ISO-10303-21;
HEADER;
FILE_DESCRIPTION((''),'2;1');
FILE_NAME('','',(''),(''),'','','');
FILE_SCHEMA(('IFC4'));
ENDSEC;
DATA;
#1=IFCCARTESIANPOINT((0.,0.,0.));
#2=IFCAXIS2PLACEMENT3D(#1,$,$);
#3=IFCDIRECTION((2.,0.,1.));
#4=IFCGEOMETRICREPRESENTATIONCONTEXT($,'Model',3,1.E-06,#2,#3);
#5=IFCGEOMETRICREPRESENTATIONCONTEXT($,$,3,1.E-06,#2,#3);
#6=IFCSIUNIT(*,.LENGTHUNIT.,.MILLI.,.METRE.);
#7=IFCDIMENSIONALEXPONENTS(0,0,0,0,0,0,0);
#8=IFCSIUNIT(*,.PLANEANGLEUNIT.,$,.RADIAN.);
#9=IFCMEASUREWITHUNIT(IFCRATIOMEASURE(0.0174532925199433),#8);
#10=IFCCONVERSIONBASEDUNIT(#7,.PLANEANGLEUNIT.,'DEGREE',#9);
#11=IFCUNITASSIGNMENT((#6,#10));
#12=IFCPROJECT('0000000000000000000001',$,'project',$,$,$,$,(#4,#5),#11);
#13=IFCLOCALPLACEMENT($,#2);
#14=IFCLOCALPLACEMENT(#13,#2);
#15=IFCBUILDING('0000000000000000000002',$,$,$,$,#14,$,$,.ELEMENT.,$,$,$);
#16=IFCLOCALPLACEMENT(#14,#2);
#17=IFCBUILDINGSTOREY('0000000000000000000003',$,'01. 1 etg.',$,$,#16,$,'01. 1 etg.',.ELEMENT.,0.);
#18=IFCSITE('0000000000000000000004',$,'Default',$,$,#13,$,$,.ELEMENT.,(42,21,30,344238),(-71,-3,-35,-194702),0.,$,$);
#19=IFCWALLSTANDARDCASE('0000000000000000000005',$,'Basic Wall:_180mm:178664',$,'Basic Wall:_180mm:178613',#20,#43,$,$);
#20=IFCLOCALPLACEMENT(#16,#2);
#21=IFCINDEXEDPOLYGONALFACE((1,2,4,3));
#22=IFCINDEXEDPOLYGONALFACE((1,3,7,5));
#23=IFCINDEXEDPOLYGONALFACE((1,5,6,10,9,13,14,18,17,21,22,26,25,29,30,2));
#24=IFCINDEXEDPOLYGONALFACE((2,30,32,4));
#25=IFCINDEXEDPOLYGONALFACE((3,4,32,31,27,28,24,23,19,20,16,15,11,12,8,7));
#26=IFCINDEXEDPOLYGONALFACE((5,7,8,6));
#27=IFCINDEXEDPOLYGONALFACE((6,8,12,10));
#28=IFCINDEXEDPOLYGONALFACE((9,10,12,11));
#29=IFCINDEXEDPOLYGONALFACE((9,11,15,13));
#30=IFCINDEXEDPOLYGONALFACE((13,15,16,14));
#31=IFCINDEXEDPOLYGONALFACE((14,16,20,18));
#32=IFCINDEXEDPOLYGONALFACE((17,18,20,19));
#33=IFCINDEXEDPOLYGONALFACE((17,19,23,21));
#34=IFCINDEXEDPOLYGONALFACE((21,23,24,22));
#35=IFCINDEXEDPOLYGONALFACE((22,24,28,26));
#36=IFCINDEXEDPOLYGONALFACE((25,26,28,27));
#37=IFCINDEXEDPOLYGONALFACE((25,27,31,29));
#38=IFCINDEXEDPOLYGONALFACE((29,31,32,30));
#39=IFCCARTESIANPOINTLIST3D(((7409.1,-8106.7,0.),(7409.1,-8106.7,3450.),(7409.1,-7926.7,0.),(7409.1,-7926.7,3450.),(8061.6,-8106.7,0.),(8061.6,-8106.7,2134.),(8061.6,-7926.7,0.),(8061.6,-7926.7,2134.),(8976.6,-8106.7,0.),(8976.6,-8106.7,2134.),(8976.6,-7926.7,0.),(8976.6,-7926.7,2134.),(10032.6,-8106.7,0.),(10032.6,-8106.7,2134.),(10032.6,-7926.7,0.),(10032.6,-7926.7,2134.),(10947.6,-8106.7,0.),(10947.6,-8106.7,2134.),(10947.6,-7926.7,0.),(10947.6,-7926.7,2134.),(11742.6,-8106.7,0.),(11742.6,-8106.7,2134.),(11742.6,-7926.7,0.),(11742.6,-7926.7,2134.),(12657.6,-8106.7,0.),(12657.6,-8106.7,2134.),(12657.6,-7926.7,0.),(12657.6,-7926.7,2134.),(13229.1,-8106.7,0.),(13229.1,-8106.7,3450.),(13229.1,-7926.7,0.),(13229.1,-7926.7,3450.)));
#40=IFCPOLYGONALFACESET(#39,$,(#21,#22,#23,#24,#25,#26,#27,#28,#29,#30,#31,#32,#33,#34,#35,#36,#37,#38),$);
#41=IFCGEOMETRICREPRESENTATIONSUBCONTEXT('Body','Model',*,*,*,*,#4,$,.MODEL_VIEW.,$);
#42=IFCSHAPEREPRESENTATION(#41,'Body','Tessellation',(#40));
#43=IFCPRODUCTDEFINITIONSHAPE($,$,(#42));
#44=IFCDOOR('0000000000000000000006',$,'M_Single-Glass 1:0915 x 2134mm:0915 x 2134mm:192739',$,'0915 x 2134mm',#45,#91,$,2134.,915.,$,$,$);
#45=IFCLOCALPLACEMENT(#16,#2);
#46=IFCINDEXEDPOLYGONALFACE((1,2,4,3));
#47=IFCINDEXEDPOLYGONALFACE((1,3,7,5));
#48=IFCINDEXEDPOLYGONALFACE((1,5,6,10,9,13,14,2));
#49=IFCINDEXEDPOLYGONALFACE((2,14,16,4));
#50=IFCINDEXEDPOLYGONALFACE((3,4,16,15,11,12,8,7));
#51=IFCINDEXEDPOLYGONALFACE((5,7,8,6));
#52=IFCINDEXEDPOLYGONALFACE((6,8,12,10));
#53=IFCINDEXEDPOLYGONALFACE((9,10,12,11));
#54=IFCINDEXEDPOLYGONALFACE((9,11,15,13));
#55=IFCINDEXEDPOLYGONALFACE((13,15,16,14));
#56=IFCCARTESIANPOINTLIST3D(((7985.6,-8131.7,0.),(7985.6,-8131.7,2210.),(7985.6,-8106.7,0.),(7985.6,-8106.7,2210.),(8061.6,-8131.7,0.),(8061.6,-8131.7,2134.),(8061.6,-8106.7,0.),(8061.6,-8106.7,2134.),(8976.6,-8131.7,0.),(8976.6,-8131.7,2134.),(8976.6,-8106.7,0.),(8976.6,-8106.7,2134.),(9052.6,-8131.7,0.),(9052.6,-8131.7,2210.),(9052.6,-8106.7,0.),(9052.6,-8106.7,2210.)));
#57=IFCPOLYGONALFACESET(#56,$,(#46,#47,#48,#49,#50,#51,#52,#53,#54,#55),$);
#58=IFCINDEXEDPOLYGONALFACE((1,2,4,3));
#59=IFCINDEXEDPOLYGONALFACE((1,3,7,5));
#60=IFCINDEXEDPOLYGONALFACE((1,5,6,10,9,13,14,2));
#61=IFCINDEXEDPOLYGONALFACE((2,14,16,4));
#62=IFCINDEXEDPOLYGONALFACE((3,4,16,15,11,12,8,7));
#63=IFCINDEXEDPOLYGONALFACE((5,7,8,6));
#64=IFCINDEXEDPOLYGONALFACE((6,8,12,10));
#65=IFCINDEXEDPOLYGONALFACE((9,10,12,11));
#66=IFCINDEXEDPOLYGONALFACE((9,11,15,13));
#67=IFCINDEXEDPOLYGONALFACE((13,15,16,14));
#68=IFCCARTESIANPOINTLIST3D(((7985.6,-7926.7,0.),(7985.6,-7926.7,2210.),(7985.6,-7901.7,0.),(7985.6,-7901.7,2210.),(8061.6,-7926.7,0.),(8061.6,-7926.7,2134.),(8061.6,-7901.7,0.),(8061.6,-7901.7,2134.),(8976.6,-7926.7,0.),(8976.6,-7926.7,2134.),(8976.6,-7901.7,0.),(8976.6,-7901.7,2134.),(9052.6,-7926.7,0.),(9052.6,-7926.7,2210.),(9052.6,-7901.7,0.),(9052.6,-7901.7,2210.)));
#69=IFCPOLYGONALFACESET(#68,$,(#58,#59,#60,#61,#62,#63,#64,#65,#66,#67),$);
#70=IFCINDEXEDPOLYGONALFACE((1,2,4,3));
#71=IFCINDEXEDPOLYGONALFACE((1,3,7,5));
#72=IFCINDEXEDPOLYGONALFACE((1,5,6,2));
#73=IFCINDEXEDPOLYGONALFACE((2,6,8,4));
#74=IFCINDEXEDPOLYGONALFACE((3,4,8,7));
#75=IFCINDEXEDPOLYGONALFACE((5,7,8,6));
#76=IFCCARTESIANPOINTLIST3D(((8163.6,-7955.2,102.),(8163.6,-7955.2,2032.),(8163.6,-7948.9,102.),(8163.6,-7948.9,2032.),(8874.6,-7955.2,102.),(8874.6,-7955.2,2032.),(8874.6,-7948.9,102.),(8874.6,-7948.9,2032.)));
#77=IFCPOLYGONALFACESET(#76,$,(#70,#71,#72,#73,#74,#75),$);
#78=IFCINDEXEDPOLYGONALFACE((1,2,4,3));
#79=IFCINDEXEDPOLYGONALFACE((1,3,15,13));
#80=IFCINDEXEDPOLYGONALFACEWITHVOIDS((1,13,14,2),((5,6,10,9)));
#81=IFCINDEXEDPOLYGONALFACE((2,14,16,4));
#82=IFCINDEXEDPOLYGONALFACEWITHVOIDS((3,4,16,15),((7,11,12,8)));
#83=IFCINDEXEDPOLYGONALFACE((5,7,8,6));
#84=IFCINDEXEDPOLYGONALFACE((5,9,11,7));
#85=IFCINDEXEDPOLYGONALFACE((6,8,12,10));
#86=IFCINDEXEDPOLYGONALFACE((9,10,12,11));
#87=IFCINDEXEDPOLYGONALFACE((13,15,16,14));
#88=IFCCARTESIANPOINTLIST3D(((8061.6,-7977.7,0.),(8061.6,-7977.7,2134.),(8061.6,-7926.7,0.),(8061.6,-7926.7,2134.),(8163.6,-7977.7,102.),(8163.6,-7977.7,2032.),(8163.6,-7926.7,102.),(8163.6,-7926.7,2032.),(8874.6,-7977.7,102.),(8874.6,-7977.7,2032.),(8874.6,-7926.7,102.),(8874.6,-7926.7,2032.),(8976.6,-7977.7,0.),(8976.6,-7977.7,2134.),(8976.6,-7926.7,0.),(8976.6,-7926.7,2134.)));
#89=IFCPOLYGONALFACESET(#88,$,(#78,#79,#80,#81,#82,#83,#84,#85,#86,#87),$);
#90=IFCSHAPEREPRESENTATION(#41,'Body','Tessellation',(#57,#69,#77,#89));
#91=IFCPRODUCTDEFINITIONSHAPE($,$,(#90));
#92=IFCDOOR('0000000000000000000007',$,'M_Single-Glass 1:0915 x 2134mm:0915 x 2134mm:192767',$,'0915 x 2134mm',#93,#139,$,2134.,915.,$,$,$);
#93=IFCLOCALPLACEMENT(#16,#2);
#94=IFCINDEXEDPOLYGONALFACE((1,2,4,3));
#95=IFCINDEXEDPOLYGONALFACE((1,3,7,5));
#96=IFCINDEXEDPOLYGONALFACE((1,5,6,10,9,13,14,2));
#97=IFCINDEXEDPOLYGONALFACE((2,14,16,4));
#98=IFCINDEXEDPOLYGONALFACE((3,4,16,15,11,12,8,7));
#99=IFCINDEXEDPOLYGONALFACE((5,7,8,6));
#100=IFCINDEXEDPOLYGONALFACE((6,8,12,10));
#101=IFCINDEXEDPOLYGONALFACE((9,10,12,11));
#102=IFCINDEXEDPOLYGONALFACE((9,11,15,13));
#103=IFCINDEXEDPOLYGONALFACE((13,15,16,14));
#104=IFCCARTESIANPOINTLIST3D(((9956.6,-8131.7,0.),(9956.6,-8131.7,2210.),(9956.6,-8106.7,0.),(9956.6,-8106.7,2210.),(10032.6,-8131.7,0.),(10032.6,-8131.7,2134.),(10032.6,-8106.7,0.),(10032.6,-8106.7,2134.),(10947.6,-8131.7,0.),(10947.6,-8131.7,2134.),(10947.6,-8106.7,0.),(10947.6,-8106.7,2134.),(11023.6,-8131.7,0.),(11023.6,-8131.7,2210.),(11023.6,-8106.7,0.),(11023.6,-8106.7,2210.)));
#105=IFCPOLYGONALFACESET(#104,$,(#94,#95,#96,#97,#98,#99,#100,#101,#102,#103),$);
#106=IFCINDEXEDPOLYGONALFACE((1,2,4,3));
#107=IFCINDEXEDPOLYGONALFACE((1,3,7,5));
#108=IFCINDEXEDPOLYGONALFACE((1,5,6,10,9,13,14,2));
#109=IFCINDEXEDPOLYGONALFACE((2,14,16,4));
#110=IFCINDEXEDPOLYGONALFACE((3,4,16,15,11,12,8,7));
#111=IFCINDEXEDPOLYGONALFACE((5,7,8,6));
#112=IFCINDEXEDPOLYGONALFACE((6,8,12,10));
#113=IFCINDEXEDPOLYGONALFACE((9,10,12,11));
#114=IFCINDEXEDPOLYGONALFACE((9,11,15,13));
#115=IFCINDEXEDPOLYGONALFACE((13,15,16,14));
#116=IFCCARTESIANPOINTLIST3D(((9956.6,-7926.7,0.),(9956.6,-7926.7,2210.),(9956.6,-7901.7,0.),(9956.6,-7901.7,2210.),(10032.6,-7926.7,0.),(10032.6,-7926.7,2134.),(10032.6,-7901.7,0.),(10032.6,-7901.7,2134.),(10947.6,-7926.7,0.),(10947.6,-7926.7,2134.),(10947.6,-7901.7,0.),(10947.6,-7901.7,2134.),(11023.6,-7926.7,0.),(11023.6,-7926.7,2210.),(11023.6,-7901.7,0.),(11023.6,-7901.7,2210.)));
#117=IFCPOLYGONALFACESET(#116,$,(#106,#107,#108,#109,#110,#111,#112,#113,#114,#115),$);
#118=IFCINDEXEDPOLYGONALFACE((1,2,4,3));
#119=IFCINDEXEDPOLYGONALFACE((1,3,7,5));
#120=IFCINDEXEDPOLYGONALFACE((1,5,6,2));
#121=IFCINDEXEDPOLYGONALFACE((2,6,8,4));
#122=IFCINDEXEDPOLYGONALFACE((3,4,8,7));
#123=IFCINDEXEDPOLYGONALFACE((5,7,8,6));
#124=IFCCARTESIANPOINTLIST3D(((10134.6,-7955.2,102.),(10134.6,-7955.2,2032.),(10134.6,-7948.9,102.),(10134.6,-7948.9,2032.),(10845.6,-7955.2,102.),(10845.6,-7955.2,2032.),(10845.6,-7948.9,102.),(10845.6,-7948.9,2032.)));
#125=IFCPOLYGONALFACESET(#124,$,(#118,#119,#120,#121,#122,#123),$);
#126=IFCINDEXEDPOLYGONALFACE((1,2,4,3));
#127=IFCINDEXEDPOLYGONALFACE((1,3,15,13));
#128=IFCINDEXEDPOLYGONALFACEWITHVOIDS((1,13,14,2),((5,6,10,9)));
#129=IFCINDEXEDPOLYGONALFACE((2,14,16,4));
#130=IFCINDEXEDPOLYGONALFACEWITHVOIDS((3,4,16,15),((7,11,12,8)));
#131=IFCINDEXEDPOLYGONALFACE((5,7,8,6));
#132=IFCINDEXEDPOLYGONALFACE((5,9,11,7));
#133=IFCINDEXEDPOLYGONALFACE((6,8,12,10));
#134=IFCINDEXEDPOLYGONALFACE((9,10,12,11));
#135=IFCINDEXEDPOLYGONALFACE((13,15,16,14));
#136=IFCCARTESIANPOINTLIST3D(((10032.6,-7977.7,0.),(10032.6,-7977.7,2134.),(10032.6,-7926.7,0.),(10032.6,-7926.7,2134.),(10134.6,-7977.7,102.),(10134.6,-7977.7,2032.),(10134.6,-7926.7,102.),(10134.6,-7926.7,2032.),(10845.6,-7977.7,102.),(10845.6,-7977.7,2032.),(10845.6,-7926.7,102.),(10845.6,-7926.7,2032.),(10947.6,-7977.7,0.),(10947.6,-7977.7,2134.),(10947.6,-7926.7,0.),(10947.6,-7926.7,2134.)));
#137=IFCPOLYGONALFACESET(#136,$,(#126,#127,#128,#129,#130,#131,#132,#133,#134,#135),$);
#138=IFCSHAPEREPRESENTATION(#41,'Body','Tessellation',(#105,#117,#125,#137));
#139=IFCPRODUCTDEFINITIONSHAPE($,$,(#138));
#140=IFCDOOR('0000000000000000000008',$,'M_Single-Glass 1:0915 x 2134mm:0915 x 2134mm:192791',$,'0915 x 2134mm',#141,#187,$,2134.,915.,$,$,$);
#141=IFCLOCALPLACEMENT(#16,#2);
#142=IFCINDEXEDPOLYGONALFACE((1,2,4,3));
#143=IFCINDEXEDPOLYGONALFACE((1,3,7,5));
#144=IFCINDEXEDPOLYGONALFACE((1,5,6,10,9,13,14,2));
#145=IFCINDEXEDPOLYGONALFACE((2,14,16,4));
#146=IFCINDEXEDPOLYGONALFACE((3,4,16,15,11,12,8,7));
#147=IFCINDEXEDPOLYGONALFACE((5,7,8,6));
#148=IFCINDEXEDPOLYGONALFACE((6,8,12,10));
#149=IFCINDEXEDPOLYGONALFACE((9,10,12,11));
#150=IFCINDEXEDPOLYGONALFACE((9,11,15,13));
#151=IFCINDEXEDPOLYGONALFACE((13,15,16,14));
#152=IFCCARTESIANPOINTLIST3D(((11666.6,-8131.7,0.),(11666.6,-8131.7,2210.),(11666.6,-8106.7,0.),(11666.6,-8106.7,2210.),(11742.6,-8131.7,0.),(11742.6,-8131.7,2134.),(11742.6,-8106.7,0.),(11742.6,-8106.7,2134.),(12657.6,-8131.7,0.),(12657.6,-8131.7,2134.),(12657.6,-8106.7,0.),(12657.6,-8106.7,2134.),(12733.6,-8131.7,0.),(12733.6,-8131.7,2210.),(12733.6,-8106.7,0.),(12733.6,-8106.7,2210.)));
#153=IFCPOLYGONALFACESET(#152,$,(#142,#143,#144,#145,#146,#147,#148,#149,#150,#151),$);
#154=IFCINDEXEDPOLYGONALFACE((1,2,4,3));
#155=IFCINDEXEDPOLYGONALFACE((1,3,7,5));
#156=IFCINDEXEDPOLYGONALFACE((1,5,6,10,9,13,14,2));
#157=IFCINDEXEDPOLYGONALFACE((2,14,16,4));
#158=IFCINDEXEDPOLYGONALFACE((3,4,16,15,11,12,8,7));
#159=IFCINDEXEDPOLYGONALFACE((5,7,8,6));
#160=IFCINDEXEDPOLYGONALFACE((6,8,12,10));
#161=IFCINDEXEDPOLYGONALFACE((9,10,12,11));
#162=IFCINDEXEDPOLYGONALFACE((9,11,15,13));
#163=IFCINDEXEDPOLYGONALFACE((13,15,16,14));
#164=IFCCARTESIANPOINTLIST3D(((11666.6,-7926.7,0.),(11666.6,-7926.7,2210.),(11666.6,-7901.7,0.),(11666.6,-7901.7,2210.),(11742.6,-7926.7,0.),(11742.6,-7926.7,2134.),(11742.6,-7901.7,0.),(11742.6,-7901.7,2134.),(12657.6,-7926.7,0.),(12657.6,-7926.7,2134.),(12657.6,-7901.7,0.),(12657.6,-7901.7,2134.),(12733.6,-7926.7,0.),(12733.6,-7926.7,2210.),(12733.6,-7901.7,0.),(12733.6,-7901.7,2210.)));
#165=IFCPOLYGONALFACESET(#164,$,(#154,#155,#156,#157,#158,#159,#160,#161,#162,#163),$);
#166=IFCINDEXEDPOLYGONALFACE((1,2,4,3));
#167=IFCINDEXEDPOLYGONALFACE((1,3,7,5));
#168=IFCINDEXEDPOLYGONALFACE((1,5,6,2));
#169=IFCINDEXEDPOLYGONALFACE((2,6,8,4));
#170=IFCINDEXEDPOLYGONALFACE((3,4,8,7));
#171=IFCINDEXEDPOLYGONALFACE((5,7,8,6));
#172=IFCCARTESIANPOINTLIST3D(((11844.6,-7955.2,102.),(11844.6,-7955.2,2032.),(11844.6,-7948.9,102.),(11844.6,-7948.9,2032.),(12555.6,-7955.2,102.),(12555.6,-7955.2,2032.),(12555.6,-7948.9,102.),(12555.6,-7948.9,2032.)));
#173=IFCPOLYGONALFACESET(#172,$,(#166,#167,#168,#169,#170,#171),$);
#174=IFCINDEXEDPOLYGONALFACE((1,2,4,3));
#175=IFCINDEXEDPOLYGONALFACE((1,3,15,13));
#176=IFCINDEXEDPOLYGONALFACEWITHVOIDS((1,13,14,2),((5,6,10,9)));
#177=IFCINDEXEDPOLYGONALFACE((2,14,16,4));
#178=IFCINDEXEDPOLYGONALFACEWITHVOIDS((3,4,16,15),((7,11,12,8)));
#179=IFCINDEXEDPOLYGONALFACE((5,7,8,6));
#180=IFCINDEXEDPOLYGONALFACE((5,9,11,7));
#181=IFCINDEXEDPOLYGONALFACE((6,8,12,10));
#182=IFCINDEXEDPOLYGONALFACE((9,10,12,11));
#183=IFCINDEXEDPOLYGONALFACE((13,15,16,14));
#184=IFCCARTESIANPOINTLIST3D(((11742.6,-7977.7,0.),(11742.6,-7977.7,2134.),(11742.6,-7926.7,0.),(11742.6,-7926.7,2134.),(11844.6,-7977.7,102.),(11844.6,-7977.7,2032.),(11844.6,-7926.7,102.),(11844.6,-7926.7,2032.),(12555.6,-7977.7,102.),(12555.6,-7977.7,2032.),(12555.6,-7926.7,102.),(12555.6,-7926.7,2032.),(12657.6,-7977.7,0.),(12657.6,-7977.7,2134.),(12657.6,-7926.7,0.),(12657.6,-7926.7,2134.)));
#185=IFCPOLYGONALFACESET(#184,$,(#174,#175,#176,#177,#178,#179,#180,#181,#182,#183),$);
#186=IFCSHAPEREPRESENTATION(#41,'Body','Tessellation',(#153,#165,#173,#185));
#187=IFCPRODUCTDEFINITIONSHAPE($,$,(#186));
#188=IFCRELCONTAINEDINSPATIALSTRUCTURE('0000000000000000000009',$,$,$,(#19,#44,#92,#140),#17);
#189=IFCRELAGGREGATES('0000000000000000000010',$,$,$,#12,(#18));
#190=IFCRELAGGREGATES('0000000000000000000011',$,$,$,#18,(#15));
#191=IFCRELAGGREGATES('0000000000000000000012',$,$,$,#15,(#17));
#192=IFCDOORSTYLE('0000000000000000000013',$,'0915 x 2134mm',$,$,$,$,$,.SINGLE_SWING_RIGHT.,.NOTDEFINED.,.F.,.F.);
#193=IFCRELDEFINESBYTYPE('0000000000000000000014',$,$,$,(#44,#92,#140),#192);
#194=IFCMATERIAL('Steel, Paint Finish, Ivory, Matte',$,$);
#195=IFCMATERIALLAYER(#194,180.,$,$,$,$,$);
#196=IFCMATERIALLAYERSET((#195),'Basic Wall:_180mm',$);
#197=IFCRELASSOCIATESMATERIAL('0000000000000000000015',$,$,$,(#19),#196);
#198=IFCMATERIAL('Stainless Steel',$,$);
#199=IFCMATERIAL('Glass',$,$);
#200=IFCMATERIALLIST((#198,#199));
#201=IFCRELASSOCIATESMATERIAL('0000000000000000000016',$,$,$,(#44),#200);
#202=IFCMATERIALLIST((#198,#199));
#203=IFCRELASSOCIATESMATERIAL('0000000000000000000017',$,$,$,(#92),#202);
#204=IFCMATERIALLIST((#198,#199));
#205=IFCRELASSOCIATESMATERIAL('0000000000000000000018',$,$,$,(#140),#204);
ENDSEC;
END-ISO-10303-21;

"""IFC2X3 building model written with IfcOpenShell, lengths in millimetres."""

from ifc_helpers import new_model, entity, si_unit, converted_unit, direction, frame, frame_2d, origin, place, context, subcontext, project, spatial, polyline, rectangle, outline, extrude, clip, bounded_halfspace, source, transform, mapped, material, material_list, layer, layer_set, layer_usage, type_object, type_shapes, element, fill, save


model = new_model("IFC2X3")

# Units and contexts
model_context = context("Model", 3, precision=1e-06, world=origin(), true_north=direction((2.0, 0.0, 1.0)))
context_of_model = context(None, 3, precision=1e-06, world=origin(), true_north=direction((2.0, 0.0, 1.0)))
body_context = subcontext(model_context, "Body", "Model", "MODEL_VIEW")
ifc_project = project(units=[si_unit("LENGTHUNIT", "METRE", prefix="MILLI"), converted_unit("PLANEANGLEUNIT", "DEGREE", entity("IfcRatioMeasure", 0.0174532925199433), si_unit("PLANEANGLEUNIT", "RADIAN"), dimensions=[0, 0, 0, 0, 0, 0, 0])], contexts=[model_context, context_of_model])

# Site, building, storey
site_placement = place(None, origin())
site = spatial("IfcSite", under=ifc_project, at=site_placement, Name="Default", CompositionType="ELEMENT", RefLatitude=(42, 21, 30, 344238), RefLongitude=(-71, -3, -35, -194702), RefElevation=0.0)
building_placement = place(site_placement, origin())
building = spatial("IfcBuilding", under=site, at=building_placement, CompositionType="ELEMENT")
storey_placement = place(building_placement, origin())
storey = spatial("IfcBuildingStorey", under=building, at=storey_placement, Name="01. 1 etg.", LongName="01. 1 etg.", CompositionType="ELEMENT", Elevation=0.0)

# Shared definitions
ifc_material_1 = material(Name="Steel, Paint Finish, Ivory, Matte")
ifc_material_2 = material(Name="Stainless Steel")
ifc_material_3 = material(Name="Glass")

# Wall, openings, doors
ifc_layer_1 = layer(ifc_material_1, 180.0)
ifc_layer_set_1 = layer_set([ifc_layer_1], Name="Basic Wall:_180mm")
ifc_layer_usage_1 = layer_usage(ifc_layer_set_1, "AXIS2", "NEGATIVE", 90.0)
wall_1_placement = place(storey_placement, frame((13229.1, -8016.7, 0.0), z_axis=(0.0, 0.0, 1.0), x_axis=(-1.0, 0.0, 0.0)))
wall_1 = element("IfcWallStandardCase", 1, at=wall_1_placement, inside=storey, material=ifc_layer_usage_1, Name="Basic Wall:_180mm:178664", ObjectType="Basic Wall:_180mm:178613", context=body_context, shape_type="Clipping", body=[
    clip(extrude(rectangle(XDim=5820.0, YDim=180.0, at=frame_2d((2910.0, 0.0), x_axis=(-1.0, 0.0))), origin(), (0.0, 0.0, 1.0), 3450.0), bounded_halfspace(frame((0.0, -90.0, 3450.0), z_axis=(0.0, 0.0, -1.0), x_axis=(0.0, 1.0, 0.0)), True, frame((0.0, -90.0, 3450.0)), polyline([(0.0, 0.0), (180.0, 0.0), (1878.0, 0.0), (1978.0, 0.0), (3500.0, 0.0), (3600.0, 0.0), (5820.0, 0.0), (5820.0, 180.0), (0.0, 180.0), (0.0, 0.0)]))),
])
opening_1_placement = place(wall_1_placement, frame((5167.5, 90.0, 0.0)))
opening_1 = element("IfcOpeningElement", 2, at=opening_1_placement, cuts=wall_1, ObjectType="Opening", context=body_context, shape_type="SweptSolid", body=[
    extrude(rectangle(XDim=915.0, YDim=2134.0, at=frame_2d((1067.0, 457.5), x_axis=(0.0, 1.0))), frame((0.0, 0.0, 0.0), z_axis=(0.0, -1.0, 0.0), x_axis=(0.0, 0.0, 1.0)), (0.0, 0.0, 1.0), 180.0),
])
opening_2_placement = place(wall_1_placement, frame((3196.5, 90.0, 0.0)))
opening_2 = element("IfcOpeningElement", 3, at=opening_2_placement, cuts=wall_1, ObjectType="Opening", context=body_context, shape_type="SweptSolid", body=[
    extrude(rectangle(XDim=915.0, YDim=2134.0, at=frame_2d((1067.0, 457.5), x_axis=(0.0, 1.0))), frame((0.0, 0.0, 0.0), z_axis=(0.0, -1.0, 0.0), x_axis=(0.0, 0.0, 1.0)), (0.0, 0.0, 1.0), 180.0),
])
opening_3_placement = place(wall_1_placement, frame((1486.5, 90.0, 0.0)))
opening_3 = element("IfcOpeningElement", 4, at=opening_3_placement, cuts=wall_1, ObjectType="Opening", context=body_context, shape_type="SweptSolid", body=[
    extrude(rectangle(XDim=915.0, YDim=2134.0, at=frame_2d((1067.0, 457.5), x_axis=(0.0, 1.0))), frame((0.0, 0.0, 0.0), z_axis=(0.0, -1.0, 0.0), x_axis=(0.0, 0.0, 1.0)), (0.0, 0.0, 1.0), 180.0),
])
ifc_material_list_1 = material_list([ifc_material_2, ifc_material_3])
door_style_1 = type_object("IfcDoorStyle", Name="0915 x 2134mm", ConstructionType="NOTDEFINED", OperationType="SINGLE_SWING_RIGHT", ParameterTakesPrecedence=False, Sizeable=False)
shared_shape_1 = source(origin(), body_context, "Body", "SweptSolid", [
    extrude(outline(polyline([(-457.5, -1048.0), (-457.5, 1086.0), (-533.5, 1086.0), (-533.5, -1124.0), (533.5, -1124.0), (533.5, 1086.0), (457.5, 1086.0), (457.5, -1048.0), (-457.5, -1048.0)])), frame((457.5, -25.0, 1086.0), z_axis=(0.0, -1.0, 0.0), x_axis=(-1.0, 0.0, 0.0)), (0.0, 0.0, -1.0), 25.0),
    extrude(outline(polyline([(-457.5, -1048.0), (-457.5, 1086.0), (-533.5, 1086.0), (-533.5, -1124.0), (533.5, -1124.0), (533.5, 1086.0), (457.5, 1086.0), (457.5, -1048.0), (-457.5, -1048.0)])), frame((457.5, 180.0, 1086.0), z_axis=(0.0, -1.0, 0.0), x_axis=(-1.0, 0.0, 0.0)), (0.0, 0.0, -1.0), 25.0),
    extrude(rectangle(XDim=6.3, YDim=711.0, at=frame_2d((0.0, 0.0), x_axis=(1.0, 0.0))), frame((457.5, 154.6, 102.0), z_axis=(0.0, 0.0, 1.0), x_axis=(0.0, 1.0, 0.0)), (0.0, 0.0, 1.0), 1930.0),
    extrude(outline(polyline([(-1067.0, -457.5), (1067.0, -457.5), (1067.0, 457.5), (-1067.0, 457.5), (-1067.0, -457.5)]), holes=[polyline([(-965.0, 355.5), (965.0, 355.5), (965.0, -355.5), (-965.0, -355.5), (-965.0, 355.5)])]), frame((457.5, 129.0, 1067.0), z_axis=(0.0, 1.0, 0.0), x_axis=(0.0, 0.0, -1.0)), (0.0, 0.0, 1.0), 51.0),
])
type_shapes(door_style_1, [shared_shape_1])
door_1_placement = place(opening_1_placement, frame((0.0, 0.0, 0.0), z_axis=(0.0, 0.0, 1.0), x_axis=(-1.0, 0.0, 0.0)))
door_1 = element("IfcDoor", 5, at=door_1_placement, inside=storey, type_object=door_style_1, material=ifc_material_list_1, Name="M_Single-Glass 1:0915 x 2134mm:0915 x 2134mm:192739", ObjectType="0915 x 2134mm", OverallHeight=2134.0, OverallWidth=915.0, context=body_context, shape_type="MappedRepresentation", body=[
    mapped(shared_shape_1, transform((0.0, 0.0, 0.0), scale=1.0)),
])
fill(opening_1, door_1)
ifc_material_list_2 = material_list([ifc_material_2, ifc_material_3])
door_2_placement = place(opening_2_placement, frame((0.0, 0.0, 0.0), z_axis=(0.0, 0.0, 1.0), x_axis=(-1.0, 0.0, 0.0)))
door_2 = element("IfcDoor", 6, at=door_2_placement, inside=storey, type_object=door_style_1, material=ifc_material_list_2, Name="M_Single-Glass 1:0915 x 2134mm:0915 x 2134mm:192767", ObjectType="0915 x 2134mm", OverallHeight=2134.0, OverallWidth=915.0, context=body_context, shape_type="MappedRepresentation", body=[
    mapped(shared_shape_1, transform((0.0, 0.0, 0.0), scale=1.0)),
])
fill(opening_2, door_2)
ifc_material_list_3 = material_list([ifc_material_2, ifc_material_3])
door_3_placement = place(opening_3_placement, frame((0.0, 0.0, 0.0), z_axis=(0.0, 0.0, 1.0), x_axis=(-1.0, 0.0, 0.0)))
door_3 = element("IfcDoor", 7, at=door_3_placement, inside=storey, type_object=door_style_1, material=ifc_material_list_3, Name="M_Single-Glass 1:0915 x 2134mm:0915 x 2134mm:192791", ObjectType="0915 x 2134mm", OverallHeight=2134.0, OverallWidth=915.0, context=body_context, shape_type="MappedRepresentation", body=[
    mapped(shared_shape_1, transform((0.0, 0.0, 0.0), scale=1.0)),
])
fill(opening_3, door_3)

save(model, "model.ifc")
